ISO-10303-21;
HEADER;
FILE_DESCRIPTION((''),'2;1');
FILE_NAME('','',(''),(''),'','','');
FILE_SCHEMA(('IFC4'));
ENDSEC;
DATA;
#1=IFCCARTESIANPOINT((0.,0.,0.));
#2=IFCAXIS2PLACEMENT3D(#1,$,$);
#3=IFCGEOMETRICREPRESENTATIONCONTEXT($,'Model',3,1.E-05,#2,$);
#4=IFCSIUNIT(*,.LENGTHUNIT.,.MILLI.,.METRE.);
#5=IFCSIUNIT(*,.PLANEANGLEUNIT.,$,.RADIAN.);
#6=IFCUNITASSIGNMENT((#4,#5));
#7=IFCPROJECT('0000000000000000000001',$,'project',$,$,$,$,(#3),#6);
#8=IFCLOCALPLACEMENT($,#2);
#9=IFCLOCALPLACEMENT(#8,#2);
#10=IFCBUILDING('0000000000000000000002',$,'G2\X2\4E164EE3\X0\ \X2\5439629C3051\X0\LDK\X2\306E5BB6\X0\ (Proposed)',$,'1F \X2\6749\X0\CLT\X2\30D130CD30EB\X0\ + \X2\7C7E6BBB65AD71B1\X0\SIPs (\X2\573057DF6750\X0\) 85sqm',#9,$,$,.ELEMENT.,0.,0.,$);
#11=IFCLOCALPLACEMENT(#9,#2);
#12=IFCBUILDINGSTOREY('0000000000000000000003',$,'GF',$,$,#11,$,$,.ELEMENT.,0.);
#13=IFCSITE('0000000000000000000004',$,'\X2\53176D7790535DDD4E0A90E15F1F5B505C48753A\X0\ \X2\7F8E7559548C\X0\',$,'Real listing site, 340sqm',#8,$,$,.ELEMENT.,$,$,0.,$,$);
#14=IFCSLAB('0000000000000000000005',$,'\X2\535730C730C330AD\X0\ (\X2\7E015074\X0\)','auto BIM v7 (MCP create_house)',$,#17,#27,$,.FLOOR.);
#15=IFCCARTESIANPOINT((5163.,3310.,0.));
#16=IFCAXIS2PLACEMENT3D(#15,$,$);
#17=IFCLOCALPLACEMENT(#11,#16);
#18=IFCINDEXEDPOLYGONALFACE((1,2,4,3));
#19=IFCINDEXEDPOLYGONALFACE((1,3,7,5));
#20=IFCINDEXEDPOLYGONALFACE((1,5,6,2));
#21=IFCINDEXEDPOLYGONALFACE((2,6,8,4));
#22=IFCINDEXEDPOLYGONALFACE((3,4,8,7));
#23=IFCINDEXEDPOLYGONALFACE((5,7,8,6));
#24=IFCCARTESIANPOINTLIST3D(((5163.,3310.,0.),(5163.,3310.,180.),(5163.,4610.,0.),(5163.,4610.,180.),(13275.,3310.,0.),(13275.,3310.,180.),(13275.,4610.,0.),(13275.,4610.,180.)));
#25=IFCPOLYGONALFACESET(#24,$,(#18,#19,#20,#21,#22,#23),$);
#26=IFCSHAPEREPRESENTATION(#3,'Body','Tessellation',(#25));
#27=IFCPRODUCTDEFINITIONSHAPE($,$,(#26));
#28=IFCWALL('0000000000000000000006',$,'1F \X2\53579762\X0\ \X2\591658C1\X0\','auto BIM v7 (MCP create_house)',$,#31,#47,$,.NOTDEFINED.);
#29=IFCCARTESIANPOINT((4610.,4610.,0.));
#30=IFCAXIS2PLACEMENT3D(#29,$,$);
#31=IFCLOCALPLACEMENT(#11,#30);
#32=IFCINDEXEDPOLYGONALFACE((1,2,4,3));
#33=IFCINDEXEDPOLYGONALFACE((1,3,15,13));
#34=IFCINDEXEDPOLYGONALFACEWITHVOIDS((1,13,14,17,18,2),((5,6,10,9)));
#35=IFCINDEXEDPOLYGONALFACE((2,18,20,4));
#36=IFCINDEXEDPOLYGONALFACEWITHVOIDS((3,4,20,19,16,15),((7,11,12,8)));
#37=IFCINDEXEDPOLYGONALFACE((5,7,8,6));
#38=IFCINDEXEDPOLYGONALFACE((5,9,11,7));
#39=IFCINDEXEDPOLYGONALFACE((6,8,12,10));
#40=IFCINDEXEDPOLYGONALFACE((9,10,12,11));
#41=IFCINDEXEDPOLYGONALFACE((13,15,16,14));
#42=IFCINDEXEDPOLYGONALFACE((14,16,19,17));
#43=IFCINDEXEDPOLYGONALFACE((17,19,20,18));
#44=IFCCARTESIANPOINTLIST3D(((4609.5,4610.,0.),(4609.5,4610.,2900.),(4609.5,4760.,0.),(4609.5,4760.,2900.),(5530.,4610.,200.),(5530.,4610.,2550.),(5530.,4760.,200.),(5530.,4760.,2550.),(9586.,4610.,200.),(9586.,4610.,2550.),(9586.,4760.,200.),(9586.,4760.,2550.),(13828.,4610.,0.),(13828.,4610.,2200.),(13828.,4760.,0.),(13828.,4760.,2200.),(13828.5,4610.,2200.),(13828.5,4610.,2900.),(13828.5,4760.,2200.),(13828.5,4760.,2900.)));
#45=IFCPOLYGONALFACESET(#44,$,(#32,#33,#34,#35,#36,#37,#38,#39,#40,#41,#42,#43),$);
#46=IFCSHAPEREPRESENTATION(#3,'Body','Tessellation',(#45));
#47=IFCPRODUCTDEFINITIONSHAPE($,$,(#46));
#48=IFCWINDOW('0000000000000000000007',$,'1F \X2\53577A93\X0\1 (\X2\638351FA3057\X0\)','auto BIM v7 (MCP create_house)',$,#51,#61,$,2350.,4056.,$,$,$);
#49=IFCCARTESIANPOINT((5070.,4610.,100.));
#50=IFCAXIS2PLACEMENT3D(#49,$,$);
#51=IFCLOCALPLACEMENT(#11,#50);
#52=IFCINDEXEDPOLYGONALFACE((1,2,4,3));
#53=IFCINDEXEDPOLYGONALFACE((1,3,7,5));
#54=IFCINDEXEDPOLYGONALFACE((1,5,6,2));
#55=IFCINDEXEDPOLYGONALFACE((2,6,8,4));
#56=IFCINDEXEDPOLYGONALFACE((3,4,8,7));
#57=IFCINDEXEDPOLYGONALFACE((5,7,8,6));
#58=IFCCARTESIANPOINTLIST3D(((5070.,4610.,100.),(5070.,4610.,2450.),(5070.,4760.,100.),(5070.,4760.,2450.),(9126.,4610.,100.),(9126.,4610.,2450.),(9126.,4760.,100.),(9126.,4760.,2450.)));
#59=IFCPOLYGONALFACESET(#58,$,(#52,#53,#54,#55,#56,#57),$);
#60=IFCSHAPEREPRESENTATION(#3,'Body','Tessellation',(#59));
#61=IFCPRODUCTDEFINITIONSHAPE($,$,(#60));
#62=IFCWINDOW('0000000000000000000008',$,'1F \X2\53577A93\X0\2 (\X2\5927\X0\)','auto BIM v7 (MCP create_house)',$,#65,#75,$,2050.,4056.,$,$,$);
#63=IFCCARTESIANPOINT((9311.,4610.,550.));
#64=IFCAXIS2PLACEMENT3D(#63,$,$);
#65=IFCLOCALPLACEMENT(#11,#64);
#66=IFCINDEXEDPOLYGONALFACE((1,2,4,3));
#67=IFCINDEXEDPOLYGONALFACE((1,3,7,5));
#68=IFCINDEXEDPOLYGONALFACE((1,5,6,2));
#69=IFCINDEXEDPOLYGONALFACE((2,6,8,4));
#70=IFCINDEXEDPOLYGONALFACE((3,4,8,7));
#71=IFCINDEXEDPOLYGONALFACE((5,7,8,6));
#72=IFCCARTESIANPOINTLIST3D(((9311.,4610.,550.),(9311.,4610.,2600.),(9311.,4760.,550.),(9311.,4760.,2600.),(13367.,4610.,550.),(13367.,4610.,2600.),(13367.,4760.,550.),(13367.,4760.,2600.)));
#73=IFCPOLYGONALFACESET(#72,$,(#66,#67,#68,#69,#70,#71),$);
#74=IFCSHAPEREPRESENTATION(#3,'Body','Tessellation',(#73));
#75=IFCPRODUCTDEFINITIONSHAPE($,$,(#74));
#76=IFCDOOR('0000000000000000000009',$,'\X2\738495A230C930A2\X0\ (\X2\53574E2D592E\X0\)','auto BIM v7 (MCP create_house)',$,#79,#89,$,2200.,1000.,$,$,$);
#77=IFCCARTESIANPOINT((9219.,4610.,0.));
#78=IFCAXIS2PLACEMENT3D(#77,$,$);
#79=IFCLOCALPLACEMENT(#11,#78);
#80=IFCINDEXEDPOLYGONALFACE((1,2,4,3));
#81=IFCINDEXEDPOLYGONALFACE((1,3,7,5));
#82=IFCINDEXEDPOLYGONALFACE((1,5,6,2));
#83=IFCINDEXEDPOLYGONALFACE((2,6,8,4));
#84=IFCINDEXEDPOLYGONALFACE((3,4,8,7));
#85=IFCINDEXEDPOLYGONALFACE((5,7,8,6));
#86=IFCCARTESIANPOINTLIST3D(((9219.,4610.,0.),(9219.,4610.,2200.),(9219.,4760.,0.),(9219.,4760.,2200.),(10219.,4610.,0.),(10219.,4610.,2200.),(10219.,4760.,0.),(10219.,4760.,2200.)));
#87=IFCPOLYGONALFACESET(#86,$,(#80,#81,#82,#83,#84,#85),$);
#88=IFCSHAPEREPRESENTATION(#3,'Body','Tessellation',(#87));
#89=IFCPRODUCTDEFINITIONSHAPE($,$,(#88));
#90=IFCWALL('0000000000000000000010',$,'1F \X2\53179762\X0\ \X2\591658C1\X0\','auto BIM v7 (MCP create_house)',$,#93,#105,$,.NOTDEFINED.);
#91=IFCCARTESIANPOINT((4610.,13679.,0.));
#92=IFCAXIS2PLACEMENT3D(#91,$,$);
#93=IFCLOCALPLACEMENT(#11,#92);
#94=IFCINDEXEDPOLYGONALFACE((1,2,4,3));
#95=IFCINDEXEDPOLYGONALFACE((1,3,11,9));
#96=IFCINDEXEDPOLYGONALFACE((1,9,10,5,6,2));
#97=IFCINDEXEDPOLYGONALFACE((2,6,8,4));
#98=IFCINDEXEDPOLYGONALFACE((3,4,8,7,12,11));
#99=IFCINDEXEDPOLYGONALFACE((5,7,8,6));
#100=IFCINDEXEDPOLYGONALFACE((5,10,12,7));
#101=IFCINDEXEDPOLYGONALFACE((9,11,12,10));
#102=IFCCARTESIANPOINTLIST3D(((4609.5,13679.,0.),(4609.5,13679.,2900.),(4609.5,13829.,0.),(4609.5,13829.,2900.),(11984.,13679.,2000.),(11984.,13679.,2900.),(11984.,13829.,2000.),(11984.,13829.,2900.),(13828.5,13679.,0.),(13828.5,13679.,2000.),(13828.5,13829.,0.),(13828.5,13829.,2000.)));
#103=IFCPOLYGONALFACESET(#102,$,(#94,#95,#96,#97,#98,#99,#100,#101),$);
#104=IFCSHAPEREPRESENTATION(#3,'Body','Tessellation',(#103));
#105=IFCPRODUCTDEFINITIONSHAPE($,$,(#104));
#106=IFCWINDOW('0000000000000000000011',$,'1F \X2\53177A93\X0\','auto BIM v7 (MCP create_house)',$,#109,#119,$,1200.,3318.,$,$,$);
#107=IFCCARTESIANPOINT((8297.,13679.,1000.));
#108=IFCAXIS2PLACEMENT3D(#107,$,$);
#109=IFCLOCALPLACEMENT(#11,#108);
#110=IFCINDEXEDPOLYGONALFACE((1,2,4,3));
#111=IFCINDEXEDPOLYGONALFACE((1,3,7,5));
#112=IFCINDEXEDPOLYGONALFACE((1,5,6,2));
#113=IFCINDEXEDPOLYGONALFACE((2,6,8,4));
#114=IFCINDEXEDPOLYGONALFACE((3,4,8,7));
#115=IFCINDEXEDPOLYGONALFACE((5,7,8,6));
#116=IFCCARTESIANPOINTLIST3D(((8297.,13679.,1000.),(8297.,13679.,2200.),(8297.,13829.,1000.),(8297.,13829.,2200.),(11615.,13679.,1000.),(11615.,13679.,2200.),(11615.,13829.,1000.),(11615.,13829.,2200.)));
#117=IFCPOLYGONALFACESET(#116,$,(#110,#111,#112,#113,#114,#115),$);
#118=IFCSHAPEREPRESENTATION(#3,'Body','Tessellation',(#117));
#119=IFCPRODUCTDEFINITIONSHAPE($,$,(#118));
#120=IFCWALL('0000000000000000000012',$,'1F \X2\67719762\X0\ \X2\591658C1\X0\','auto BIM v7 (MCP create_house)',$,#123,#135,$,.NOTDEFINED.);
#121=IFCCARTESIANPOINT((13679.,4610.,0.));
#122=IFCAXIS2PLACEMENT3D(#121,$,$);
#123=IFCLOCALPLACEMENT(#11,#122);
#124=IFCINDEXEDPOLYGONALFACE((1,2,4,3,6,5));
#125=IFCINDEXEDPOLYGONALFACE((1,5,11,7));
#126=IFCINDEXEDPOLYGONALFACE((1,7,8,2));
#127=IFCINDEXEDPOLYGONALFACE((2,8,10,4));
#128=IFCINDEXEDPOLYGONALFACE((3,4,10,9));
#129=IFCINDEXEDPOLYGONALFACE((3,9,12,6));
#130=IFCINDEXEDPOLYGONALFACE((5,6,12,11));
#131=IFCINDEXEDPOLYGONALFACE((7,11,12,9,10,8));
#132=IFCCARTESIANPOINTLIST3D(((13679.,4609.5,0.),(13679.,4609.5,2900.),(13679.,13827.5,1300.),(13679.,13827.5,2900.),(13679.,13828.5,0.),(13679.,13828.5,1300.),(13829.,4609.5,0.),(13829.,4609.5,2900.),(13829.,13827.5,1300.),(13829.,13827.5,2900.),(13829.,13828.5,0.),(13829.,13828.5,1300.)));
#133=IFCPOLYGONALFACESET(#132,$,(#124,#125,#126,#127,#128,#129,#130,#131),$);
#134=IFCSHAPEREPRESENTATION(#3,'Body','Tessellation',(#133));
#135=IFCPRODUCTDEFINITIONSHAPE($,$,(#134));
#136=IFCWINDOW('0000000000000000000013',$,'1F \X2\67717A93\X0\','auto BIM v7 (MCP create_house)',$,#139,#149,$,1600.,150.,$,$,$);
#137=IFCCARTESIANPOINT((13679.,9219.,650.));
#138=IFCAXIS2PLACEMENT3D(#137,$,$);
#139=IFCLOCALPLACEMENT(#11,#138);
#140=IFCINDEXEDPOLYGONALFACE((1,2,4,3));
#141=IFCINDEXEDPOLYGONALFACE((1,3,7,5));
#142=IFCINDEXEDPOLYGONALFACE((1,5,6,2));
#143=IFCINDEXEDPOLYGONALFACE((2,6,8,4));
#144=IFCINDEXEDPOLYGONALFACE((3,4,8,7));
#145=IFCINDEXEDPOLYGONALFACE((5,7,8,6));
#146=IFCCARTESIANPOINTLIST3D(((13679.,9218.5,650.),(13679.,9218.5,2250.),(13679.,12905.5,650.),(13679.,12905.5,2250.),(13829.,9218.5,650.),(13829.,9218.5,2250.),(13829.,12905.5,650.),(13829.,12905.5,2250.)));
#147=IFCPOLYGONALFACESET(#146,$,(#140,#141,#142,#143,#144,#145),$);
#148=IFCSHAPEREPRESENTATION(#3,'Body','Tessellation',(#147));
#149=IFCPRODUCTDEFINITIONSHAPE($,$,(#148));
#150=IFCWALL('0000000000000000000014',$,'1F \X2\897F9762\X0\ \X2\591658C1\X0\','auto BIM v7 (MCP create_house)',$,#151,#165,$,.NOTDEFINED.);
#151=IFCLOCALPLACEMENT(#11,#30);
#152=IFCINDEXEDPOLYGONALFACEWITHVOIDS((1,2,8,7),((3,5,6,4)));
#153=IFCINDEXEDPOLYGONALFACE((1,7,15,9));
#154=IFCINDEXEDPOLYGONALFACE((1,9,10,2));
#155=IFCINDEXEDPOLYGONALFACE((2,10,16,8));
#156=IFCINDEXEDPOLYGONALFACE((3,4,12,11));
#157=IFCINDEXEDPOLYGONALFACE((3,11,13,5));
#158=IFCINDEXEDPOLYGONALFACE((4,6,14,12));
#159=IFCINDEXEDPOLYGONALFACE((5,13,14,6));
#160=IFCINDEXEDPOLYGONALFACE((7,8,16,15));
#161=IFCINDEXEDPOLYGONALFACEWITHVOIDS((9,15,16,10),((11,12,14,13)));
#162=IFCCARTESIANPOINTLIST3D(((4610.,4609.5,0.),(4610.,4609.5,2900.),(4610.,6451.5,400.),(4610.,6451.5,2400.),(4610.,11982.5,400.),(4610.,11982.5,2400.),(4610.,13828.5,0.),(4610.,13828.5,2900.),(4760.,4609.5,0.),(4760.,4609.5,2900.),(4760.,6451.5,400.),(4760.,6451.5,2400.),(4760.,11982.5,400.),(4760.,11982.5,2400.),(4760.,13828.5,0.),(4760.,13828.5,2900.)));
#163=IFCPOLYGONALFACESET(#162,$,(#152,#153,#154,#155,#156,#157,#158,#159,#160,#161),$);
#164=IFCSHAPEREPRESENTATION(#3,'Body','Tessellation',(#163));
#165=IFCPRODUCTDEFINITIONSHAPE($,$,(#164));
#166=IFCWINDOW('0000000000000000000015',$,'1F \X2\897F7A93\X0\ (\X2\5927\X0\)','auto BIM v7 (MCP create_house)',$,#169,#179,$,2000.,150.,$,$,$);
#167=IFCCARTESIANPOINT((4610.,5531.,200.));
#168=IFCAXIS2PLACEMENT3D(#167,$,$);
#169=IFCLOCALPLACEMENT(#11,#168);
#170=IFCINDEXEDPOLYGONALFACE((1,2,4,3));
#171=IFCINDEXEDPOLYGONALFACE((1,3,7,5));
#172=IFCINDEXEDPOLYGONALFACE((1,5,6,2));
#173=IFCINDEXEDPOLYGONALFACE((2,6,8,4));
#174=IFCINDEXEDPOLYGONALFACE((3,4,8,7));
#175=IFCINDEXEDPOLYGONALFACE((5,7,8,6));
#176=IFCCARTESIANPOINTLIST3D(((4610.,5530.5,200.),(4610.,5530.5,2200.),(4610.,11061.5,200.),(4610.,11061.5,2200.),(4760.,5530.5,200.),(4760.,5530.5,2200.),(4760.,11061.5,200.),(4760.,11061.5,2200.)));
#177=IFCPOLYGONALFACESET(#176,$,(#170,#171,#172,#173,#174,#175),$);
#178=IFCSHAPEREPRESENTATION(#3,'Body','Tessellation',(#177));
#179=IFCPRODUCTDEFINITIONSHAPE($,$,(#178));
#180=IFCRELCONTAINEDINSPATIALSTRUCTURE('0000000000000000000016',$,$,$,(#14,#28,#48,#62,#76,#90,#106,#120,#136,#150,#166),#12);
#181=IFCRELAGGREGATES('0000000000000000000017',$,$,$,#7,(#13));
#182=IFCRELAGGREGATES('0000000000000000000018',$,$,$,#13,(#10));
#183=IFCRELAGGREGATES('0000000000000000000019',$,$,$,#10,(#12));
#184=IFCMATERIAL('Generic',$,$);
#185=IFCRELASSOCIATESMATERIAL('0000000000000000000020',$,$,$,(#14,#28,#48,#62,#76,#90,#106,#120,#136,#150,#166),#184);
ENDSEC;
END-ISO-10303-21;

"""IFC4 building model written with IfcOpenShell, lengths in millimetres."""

from ifc_helpers import new_model, si_unit, frame, frame_2d, origin, place, context, project, spatial, rectangle, extrude, material, element, fill, save


model = new_model("IFC4")

# Units and contexts
model_context = context("Model", 3, precision=1e-05, world=origin())
ifc_project = project(units=[si_unit("LENGTHUNIT", "METRE", prefix="MILLI"), si_unit("PLANEANGLEUNIT", "RADIAN")], contexts=[model_context])

# Site, building, storey
site_placement = place(None, origin())
site = spatial("IfcSite", under=ifc_project, at=site_placement, Name="北海道川上郡弟子屈町 美留和", ObjectType="Real listing site, 340sqm", CompositionType="ELEMENT", RefElevation=0.0)
building_placement = place(site_placement, origin())
building = spatial("IfcBuilding", under=site, at=building_placement, Name="G2世代 吹抜けLDKの家 (Proposed)", ObjectType="1F 杉CLTパネル + 籾殻断熱SIPs (地域材) 85sqm", CompositionType="ELEMENT", ElevationOfRefHeight=0.0, ElevationOfTerrain=0.0)
storey_placement = place(building_placement, origin())
storey = spatial("IfcBuildingStorey", under=building, at=storey_placement, Name="GF", CompositionType="ELEMENT", Elevation=0.0)

# Slab
ifc_material = material(Name="Generic")
slab_1_placement = place(storey_placement, frame((5163.0, 3310.0, 0.0)))
element("IfcSlab", 1, at=slab_1_placement, inside=storey, material=ifc_material, Name="南デッキ (縁側)", Description="auto BIM v7 (MCP create_house)", PredefinedType="FLOOR", context=model_context, shape_type="SweptSolid", body=[
    extrude(rectangle(XDim=8112.0, YDim=1300.0, at=frame_2d((4056.0, 650.0))), frame((5163.0, 3310.0, 0.0)), (0.0, 0.0, 1.0), 180.0),
])

# Wall, openings, windows, door
wall_1_placement = place(storey_placement, frame((4610.0, 4610.0, 0.0)))
wall_1 = element("IfcWall", 2, at=wall_1_placement, inside=storey, material=ifc_material, Name="1F 南面 外壁", Description="auto BIM v7 (MCP create_house)", PredefinedType="NOTDEFINED", context=model_context, shape_type="SweptSolid", body=[
    extrude(rectangle(XDim=9219.0, YDim=150.0, at=frame_2d((4609.0, 75.0))), frame((4610.0, 4610.0, 0.0)), (0.0, 0.0, 1.0), 2900.0),
])
opening_1_placement = place(storey_placement, frame((5070.0, 4610.0, 100.0)))
opening_1 = element("IfcOpeningElement", 3, at=opening_1_placement, cuts=wall_1, PredefinedType="NOTDEFINED", context=model_context, shape_type="SweptSolid", body=[
    extrude(rectangle(XDim=4056.0, YDim=150.0, at=frame_2d((2028.0, 75.0))), frame((5070.0, 4610.0, 100.0)), (0.0, 0.0, 1.0), 2350.0),
])
opening_2_placement = place(storey_placement, frame((9311.0, 4610.0, 550.0)))
opening_2 = element("IfcOpeningElement", 4, at=opening_2_placement, cuts=wall_1, PredefinedType="NOTDEFINED", context=model_context, shape_type="SweptSolid", body=[
    extrude(rectangle(XDim=4056.0, YDim=150.0, at=frame_2d((2028.0, 75.0))), frame((9311.0, 4610.0, 550.0)), (0.0, 0.0, 1.0), 2050.0),
])
opening_3_placement = place(storey_placement, frame((9219.0, 4610.0, 0.0)))
opening_3 = element("IfcOpeningElement", 5, at=opening_3_placement, cuts=wall_1, PredefinedType="NOTDEFINED", context=model_context, shape_type="SweptSolid", body=[
    extrude(rectangle(XDim=1000.0, YDim=150.0, at=frame_2d((500.0, 75.0))), frame((9219.0, 4610.0, 0.0)), (0.0, 0.0, 1.0), 2200.0),
])
window_1_placement = place(storey_placement, frame((5070.0, 4610.0, 100.0)))
window_1 = element("IfcWindow", 6, at=window_1_placement, inside=storey, material=ifc_material, Name="1F 南窓1 (掃出し)", Description="auto BIM v7 (MCP create_house)", OverallHeight=2350.0, OverallWidth=4056.0, context=model_context, shape_type="SweptSolid", body=[
    extrude(rectangle(XDim=4056.0, YDim=150.0, at=frame_2d((2028.0, 75.0))), frame((5070.0, 4610.0, 100.0)), (0.0, 0.0, 1.0), 2350.0),
])
fill(opening_1, window_1)
window_2_placement = place(storey_placement, frame((9311.0, 4610.0, 550.0)))
window_2 = element("IfcWindow", 7, at=window_2_placement, inside=storey, material=ifc_material, Name="1F 南窓2 (大)", Description="auto BIM v7 (MCP create_house)", OverallHeight=2050.0, OverallWidth=4056.0, context=model_context, shape_type="SweptSolid", body=[
    extrude(rectangle(XDim=4056.0, YDim=150.0, at=frame_2d((2028.0, 75.0))), frame((9311.0, 4610.0, 550.0)), (0.0, 0.0, 1.0), 2050.0),
])
fill(opening_2, window_2)
door_placement = place(storey_placement, frame((9219.0, 4610.0, 0.0)))
door = element("IfcDoor", 8, at=door_placement, inside=storey, material=ifc_material, Name="玄関ドア (南中央)", Description="auto BIM v7 (MCP create_house)", OverallHeight=2200.0, OverallWidth=1000.0, context=model_context, shape_type="SweptSolid", body=[
    extrude(rectangle(XDim=1000.0, YDim=150.0, at=frame_2d((500.0, 75.0))), frame((9219.0, 4610.0, 0.0)), (0.0, 0.0, 1.0), 2200.0),
])
fill(opening_3, door)

# Walls, openings, windows
wall_2_placement = place(storey_placement, frame((4610.0, 13679.0, 0.0)))
wall_2 = element("IfcWall", 9, at=wall_2_placement, inside=storey, material=ifc_material, Name="1F 北面 外壁", Description="auto BIM v7 (MCP create_house)", PredefinedType="NOTDEFINED", context=model_context, shape_type="SweptSolid", body=[
    extrude(rectangle(XDim=9219.0, YDim=150.0, at=frame_2d((4609.0, 75.0))), frame((4610.0, 13679.0, 0.0)), (0.0, 0.0, 1.0), 2900.0),
])
opening_4_placement = place(storey_placement, frame((8297.0, 13679.0, 1000.0)))
opening_4 = element("IfcOpeningElement", 10, at=opening_4_placement, cuts=wall_2, PredefinedType="NOTDEFINED", context=model_context, shape_type="SweptSolid", body=[
    extrude(rectangle(XDim=3318.0, YDim=150.0, at=frame_2d((1659.0, 75.0))), frame((8297.0, 13679.0, 1000.0)), (0.0, 0.0, 1.0), 1200.0),
])
window_3_placement = place(storey_placement, frame((8297.0, 13679.0, 1000.0)))
window_3 = element("IfcWindow", 11, at=window_3_placement, inside=storey, material=ifc_material, Name="1F 北窓", Description="auto BIM v7 (MCP create_house)", OverallHeight=1200.0, OverallWidth=3318.0, context=model_context, shape_type="SweptSolid", body=[
    extrude(rectangle(XDim=3318.0, YDim=150.0, at=frame_2d((1659.0, 75.0))), frame((8297.0, 13679.0, 1000.0)), (0.0, 0.0, 1.0), 1200.0),
])
fill(opening_4, window_3)
wall_3_placement = place(storey_placement, frame((13679.0, 4610.0, 0.0)))
wall_3 = element("IfcWall", 12, at=wall_3_placement, inside=storey, material=ifc_material, Name="1F 東面 外壁", Description="auto BIM v7 (MCP create_house)", PredefinedType="NOTDEFINED", context=model_context, shape_type="SweptSolid", body=[
    extrude(rectangle(XDim=150.0, YDim=9219.0, at=frame_2d((75.0, 4609.0))), frame((13679.0, 4610.0, 0.0)), (0.0, 0.0, 1.0), 2900.0),
])
opening_5_placement = place(storey_placement, frame((13679.0, 9219.0, 650.0)))
opening_5 = element("IfcOpeningElement", 13, at=opening_5_placement, cuts=wall_3, PredefinedType="NOTDEFINED", context=model_context, shape_type="SweptSolid", body=[
    extrude(rectangle(XDim=150.0, YDim=3687.0, at=frame_2d((75.0, 1843.0))), frame((13679.0, 9219.0, 650.0)), (0.0, 0.0, 1.0), 1600.0),
])
window_4_placement = place(storey_placement, frame((13679.0, 9219.0, 650.0)))
window_4 = element("IfcWindow", 14, at=window_4_placement, inside=storey, material=ifc_material, Name="1F 東窓", Description="auto BIM v7 (MCP create_house)", OverallHeight=1600.0, OverallWidth=150.0, context=model_context, shape_type="SweptSolid", body=[
    extrude(rectangle(XDim=150.0, YDim=3687.0, at=frame_2d((75.0, 1843.0))), frame((13679.0, 9219.0, 650.0)), (0.0, 0.0, 1.0), 1600.0),
])
fill(opening_5, window_4)
wall_4_placement = place(storey_placement, frame((4610.0, 4610.0, 0.0)))
wall_4 = element("IfcWall", 15, at=wall_4_placement, inside=storey, material=ifc_material, Name="1F 西面 外壁", Description="auto BIM v7 (MCP create_house)", PredefinedType="NOTDEFINED", context=model_context, shape_type="SweptSolid", body=[
    extrude(rectangle(XDim=150.0, YDim=9219.0, at=frame_2d((75.0, 4609.0))), frame((4610.0, 4610.0, 0.0)), (0.0, 0.0, 1.0), 2900.0),
])
opening_6_placement = place(storey_placement, frame((4610.0, 5531.0, 200.0)))
opening_6 = element("IfcOpeningElement", 16, at=opening_6_placement, cuts=wall_4, PredefinedType="NOTDEFINED", context=model_context, shape_type="SweptSolid", body=[
    extrude(rectangle(XDim=150.0, YDim=5531.0, at=frame_2d((75.0, 2765.0))), frame((4610.0, 5531.0, 200.0)), (0.0, 0.0, 1.0), 2000.0),
])
window_5_placement = place(storey_placement, frame((4610.0, 5531.0, 200.0)))
window_5 = element("IfcWindow", 17, at=window_5_placement, inside=storey, material=ifc_material, Name="1F 西窓 (大)", Description="auto BIM v7 (MCP create_house)", OverallHeight=2000.0, OverallWidth=150.0, context=model_context, shape_type="SweptSolid", body=[
    extrude(rectangle(XDim=150.0, YDim=5531.0, at=frame_2d((75.0, 2765.0))), frame((4610.0, 5531.0, 200.0)), (0.0, 0.0, 1.0), 2000.0),
])
fill(opening_6, window_5)

save(model, "model.ifc")
